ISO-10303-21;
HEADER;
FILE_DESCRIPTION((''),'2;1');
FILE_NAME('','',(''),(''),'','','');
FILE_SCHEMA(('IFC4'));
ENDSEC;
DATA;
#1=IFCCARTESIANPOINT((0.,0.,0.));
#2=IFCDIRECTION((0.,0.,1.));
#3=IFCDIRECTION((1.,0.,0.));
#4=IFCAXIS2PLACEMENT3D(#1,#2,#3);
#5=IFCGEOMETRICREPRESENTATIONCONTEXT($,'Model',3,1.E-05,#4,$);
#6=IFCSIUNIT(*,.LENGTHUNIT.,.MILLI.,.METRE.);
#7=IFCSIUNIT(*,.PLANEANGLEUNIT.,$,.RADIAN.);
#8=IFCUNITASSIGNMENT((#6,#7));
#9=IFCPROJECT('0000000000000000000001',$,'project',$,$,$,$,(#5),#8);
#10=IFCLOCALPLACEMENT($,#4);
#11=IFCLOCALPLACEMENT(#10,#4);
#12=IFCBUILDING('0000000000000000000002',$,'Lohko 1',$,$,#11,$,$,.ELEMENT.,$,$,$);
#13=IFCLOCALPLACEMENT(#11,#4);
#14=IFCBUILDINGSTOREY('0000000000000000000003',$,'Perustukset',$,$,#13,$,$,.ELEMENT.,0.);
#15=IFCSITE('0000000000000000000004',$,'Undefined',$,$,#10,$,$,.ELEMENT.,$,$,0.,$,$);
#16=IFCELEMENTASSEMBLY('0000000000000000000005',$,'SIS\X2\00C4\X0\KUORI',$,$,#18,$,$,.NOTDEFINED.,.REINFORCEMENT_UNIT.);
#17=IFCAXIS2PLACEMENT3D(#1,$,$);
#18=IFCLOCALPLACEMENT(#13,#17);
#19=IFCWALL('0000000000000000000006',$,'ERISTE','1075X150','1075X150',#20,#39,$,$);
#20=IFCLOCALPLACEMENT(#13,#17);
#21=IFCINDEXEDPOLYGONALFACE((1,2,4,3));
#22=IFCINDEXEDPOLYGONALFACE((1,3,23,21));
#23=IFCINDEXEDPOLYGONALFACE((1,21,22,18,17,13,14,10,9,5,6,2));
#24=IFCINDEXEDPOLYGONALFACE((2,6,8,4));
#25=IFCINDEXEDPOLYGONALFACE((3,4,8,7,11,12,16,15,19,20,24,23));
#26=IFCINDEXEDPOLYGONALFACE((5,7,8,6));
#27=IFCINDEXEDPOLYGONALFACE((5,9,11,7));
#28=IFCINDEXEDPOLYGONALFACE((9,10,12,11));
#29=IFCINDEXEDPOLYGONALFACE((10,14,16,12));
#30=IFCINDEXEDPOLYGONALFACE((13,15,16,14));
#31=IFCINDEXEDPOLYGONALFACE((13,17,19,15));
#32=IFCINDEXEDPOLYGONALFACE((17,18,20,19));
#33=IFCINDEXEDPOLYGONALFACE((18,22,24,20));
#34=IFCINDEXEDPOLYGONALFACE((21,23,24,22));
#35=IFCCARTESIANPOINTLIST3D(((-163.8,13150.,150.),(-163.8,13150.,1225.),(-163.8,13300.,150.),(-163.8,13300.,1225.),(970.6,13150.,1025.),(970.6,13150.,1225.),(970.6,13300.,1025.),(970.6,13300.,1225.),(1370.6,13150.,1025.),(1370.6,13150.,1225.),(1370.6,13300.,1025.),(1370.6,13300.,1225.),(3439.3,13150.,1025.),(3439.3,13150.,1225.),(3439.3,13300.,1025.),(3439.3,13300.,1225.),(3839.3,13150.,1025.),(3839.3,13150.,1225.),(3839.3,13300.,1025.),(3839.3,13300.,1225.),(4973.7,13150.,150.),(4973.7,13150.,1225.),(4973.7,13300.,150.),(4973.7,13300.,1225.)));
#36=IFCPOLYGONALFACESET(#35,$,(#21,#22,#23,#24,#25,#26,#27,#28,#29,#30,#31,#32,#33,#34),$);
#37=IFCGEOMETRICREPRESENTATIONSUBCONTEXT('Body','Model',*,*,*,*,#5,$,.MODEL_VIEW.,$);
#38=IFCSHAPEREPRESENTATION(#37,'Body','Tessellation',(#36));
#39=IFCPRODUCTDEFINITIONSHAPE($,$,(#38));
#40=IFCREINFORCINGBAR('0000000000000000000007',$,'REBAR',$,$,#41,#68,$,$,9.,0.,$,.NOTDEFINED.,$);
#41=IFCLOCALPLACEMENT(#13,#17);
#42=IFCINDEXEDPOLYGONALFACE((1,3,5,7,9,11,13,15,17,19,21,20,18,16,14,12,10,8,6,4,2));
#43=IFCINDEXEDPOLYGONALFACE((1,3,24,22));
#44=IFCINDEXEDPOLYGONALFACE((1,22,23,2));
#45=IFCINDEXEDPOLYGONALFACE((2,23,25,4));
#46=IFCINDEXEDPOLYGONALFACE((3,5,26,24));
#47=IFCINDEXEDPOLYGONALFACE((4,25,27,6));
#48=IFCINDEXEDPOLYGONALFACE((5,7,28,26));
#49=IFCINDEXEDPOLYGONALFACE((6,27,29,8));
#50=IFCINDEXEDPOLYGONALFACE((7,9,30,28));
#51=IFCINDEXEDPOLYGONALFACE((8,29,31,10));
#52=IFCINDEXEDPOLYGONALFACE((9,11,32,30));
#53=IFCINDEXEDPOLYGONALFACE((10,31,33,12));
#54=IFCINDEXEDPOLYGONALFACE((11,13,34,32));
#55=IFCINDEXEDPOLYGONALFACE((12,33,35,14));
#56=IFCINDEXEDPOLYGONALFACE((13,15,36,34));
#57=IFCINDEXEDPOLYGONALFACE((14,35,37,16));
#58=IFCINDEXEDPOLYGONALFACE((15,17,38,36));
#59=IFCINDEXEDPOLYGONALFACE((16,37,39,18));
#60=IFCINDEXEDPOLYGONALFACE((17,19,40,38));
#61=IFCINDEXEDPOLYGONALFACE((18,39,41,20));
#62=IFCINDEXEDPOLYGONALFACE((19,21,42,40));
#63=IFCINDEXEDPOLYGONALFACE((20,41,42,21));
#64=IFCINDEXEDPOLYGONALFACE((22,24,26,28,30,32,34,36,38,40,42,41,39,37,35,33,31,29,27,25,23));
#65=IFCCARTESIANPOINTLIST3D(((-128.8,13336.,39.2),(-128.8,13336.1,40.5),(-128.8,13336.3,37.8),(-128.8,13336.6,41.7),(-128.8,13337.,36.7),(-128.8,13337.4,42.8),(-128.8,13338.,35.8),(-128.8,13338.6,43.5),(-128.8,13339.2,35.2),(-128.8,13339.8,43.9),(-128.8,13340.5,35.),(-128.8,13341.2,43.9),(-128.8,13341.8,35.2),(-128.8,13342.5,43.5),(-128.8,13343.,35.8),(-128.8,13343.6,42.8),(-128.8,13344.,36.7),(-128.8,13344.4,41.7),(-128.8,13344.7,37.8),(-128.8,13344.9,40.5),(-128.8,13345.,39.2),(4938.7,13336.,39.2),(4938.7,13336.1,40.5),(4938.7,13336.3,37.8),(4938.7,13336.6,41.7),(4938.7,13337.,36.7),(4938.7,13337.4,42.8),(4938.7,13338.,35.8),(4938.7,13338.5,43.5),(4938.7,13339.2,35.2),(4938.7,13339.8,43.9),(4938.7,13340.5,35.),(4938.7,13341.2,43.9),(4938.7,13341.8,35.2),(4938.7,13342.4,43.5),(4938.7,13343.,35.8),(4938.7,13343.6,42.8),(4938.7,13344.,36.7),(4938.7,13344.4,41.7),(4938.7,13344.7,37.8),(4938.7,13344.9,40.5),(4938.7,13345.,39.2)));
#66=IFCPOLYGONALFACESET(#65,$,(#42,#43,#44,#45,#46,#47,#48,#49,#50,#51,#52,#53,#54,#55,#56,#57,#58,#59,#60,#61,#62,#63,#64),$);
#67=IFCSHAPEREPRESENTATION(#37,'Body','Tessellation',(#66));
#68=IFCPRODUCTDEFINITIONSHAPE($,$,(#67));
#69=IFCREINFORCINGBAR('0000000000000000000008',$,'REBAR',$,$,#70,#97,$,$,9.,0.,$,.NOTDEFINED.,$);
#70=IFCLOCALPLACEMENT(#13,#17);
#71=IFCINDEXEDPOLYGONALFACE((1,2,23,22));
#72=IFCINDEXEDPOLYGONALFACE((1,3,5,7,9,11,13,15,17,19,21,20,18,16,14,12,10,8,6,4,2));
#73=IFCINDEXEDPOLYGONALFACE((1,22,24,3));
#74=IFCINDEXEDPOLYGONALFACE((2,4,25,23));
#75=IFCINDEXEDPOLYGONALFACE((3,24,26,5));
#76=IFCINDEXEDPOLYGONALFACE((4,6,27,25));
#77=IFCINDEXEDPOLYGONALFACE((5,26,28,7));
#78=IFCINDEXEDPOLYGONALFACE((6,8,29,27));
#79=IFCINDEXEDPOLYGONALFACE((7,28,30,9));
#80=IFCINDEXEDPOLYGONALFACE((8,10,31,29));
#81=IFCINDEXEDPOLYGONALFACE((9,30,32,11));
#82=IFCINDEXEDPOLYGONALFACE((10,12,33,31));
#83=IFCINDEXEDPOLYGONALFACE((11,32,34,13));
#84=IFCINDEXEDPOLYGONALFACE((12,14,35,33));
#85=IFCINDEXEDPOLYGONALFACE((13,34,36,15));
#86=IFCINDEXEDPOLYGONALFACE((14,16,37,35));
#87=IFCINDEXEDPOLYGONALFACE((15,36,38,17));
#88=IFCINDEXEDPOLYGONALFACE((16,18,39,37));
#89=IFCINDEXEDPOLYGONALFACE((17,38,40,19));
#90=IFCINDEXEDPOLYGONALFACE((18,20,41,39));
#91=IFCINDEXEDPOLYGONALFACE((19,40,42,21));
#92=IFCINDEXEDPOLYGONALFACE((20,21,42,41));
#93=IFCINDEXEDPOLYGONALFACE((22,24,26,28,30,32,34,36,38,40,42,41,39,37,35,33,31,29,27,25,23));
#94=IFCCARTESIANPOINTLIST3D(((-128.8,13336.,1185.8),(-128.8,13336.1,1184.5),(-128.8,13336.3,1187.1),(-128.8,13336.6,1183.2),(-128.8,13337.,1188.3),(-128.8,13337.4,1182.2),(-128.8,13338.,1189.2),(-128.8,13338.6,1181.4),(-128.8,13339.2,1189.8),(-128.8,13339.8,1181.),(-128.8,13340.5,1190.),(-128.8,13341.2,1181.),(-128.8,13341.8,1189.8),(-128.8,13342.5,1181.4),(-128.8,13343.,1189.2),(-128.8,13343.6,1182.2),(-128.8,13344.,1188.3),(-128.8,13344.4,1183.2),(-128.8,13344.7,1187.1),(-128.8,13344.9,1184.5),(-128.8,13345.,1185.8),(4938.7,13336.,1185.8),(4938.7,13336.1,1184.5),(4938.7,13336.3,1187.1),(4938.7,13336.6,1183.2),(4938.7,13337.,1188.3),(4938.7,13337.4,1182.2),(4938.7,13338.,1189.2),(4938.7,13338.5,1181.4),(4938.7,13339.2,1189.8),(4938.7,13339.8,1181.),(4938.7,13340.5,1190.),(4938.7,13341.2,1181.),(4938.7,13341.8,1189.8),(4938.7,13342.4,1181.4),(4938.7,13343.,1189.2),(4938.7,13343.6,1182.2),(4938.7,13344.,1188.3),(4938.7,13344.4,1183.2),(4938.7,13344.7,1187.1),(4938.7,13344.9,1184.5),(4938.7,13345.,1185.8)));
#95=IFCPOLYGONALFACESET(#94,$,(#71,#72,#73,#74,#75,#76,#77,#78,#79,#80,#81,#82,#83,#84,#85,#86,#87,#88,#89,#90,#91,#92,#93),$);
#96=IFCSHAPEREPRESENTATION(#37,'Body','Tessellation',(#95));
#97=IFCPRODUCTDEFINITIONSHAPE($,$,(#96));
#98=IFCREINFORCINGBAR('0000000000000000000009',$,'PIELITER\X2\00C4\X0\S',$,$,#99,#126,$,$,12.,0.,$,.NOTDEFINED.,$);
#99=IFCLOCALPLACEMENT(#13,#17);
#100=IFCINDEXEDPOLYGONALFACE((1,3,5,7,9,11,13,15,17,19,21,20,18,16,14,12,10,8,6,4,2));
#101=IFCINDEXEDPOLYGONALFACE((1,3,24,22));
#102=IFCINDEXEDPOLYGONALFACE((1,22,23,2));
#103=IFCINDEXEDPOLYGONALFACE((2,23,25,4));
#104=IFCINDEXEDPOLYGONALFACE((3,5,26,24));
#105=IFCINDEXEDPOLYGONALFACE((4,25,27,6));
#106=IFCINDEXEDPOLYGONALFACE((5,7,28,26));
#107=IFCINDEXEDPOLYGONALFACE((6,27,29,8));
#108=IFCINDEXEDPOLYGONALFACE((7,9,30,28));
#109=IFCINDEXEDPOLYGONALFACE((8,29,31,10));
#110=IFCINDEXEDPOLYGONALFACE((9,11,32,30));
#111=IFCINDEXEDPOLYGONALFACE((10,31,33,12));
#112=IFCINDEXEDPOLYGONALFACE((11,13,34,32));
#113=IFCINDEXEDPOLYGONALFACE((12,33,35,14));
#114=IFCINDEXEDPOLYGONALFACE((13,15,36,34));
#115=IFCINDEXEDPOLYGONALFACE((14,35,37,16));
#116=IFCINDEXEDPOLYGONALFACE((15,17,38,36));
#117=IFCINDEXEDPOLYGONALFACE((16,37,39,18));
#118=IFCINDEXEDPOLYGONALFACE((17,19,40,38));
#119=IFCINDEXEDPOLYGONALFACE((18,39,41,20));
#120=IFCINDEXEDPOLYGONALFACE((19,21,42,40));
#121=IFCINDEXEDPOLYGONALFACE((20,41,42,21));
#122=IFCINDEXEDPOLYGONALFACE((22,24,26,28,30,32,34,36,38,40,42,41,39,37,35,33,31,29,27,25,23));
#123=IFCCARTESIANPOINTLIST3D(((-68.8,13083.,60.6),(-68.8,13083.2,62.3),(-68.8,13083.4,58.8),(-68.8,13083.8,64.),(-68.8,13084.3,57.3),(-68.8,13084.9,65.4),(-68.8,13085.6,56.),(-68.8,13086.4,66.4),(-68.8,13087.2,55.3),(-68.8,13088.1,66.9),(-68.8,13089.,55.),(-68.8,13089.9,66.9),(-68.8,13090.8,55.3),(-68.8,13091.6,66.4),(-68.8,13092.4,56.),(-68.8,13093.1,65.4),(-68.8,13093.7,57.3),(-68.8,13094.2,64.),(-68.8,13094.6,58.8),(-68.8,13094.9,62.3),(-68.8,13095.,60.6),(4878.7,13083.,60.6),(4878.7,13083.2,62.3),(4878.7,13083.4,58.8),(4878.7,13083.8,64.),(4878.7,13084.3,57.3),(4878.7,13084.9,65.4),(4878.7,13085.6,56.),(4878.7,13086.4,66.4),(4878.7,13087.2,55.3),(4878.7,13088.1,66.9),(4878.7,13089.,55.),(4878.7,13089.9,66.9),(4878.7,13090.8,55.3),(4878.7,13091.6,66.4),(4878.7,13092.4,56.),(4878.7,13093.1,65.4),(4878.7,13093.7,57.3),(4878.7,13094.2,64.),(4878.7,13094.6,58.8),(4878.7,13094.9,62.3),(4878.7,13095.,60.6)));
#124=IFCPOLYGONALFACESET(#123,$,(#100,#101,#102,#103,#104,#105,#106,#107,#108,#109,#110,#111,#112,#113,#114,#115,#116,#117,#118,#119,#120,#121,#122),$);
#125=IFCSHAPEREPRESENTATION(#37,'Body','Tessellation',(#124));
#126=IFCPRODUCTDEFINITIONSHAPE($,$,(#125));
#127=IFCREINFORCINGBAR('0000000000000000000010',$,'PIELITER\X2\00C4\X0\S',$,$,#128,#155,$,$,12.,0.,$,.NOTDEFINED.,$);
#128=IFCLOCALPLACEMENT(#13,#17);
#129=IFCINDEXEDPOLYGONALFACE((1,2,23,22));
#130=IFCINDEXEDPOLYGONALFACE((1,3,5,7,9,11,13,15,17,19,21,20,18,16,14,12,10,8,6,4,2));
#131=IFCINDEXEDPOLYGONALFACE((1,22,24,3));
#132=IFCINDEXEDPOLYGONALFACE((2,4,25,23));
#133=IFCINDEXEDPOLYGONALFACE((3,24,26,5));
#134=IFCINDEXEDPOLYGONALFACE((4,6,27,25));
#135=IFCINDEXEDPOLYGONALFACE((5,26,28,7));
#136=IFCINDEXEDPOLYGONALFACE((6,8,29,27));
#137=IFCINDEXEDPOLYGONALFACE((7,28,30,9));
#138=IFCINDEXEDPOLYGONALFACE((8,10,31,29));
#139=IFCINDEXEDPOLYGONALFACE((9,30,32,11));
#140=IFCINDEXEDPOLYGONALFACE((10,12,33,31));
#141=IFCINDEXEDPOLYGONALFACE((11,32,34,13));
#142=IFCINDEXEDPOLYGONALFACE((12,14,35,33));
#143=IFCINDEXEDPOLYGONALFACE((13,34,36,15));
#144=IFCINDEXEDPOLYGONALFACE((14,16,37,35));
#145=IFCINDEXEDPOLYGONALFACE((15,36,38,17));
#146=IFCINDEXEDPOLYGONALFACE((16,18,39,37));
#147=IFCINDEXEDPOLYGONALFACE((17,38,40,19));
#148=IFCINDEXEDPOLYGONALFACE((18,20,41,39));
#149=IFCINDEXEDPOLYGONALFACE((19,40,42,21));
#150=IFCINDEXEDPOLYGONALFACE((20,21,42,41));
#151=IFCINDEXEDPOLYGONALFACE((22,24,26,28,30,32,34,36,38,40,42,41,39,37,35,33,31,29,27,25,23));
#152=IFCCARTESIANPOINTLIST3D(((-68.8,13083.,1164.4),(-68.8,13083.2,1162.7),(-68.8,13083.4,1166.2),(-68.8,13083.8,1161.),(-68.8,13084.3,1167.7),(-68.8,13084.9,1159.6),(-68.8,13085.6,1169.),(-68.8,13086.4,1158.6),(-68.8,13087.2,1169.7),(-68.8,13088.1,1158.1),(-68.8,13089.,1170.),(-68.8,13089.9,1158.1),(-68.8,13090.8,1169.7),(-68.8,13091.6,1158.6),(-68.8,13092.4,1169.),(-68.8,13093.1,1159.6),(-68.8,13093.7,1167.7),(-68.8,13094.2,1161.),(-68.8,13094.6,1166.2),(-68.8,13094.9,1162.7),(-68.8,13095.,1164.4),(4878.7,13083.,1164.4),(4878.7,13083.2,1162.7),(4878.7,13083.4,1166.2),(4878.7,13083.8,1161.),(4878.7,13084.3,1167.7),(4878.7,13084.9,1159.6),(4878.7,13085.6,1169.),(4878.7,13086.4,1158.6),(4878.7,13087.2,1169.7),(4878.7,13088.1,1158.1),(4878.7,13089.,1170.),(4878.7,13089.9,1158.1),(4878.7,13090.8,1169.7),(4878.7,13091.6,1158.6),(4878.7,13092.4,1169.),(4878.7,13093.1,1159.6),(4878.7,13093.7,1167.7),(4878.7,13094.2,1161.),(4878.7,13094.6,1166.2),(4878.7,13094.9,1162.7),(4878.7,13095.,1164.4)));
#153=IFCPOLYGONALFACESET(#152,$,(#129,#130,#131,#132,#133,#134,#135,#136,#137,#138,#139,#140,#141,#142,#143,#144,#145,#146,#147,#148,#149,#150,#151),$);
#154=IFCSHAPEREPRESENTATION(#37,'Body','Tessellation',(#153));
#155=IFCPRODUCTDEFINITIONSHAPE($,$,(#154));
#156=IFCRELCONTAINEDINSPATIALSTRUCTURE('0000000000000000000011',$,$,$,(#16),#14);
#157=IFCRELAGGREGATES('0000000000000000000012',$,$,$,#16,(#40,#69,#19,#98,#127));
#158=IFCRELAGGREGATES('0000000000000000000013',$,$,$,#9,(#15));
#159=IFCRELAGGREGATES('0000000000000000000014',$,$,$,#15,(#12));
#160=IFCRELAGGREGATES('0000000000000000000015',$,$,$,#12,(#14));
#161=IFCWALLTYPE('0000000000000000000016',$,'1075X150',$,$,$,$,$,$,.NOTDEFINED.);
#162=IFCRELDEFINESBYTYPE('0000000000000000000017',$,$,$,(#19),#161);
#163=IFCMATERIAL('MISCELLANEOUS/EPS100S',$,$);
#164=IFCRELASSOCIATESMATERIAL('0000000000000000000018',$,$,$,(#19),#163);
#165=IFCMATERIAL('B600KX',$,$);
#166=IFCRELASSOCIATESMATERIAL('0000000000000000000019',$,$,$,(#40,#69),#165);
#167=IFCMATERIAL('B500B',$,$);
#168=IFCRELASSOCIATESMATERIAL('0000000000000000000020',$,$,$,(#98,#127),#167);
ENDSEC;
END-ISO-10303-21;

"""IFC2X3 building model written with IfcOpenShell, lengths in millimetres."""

from ifc_helpers import new_model, entity, si_unit, frame, frame_2d, origin_with_axes, place, context, subcontext, project, spatial, polyline, rectangle, outline, extrude, boolean, source, transform, mapped, material, type_object, element, aggregate, save


model = new_model("IFC2X3")

# Units and contexts
model_context = context("Model", 3, precision=1e-05, world=origin_with_axes())
body_context = subcontext(model_context, "Body", "Model", "MODEL_VIEW")
ifc_project = project(units=[si_unit("LENGTHUNIT", "METRE", prefix="MILLI"), si_unit("PLANEANGLEUNIT", "RADIAN")], contexts=[model_context])

# Site, building, storey
site_placement = place(None, origin_with_axes())
site = spatial("IfcSite", under=ifc_project, at=site_placement, Name="Undefined", CompositionType="ELEMENT", RefElevation=0.0)
building_placement = place(site_placement, origin_with_axes())
building = spatial("IfcBuilding", under=site, at=building_placement, Name="Lohko 1", CompositionType="ELEMENT")
storey_placement = place(building_placement, origin_with_axes())
storey = spatial("IfcBuildingStorey", under=building, at=storey_placement, Name="Perustukset", CompositionType="ELEMENT", Elevation=0.0)

# Element assembly, wall, reinforcing bars
assembly_placement = place(storey_placement, origin_with_axes())
assembly = element("IfcElementAssembly", 1, at=assembly_placement, inside=storey, Name="SISÄKUORI", AssemblyPlace="NOTDEFINED", PredefinedType="REINFORCEMENT_UNIT")
ifc_material_1 = material(Name="MISCELLANEOUS/EPS100S")
wall_type_1 = type_object("IfcWallType", Name="1075X150", PredefinedType="NOTDEFINED")
wall_1_placement = place(assembly_placement, frame((-163.8, 13225.0, 150.0), z_axis=(0.0, 0.0, 1.0), x_axis=(1.0, 0.0, 0.0)))
wall_1 = element("IfcWall", 2, at=wall_1_placement, type_object=wall_type_1, material=ifc_material_1, Name="ERISTE", Description="1075X150", ObjectType="1075X150", context=body_context, shape_type="CSG", body=[
    boolean("DIFFERENCE", boolean("DIFFERENCE", extrude(rectangle(XDim=5137.5, YDim=150.0, at=frame_2d((0.0, 2568.7), x_axis=(0.0, -1.0))), frame((0.0, 0.0, 0.0), z_axis=(0.0, 0.0, 1.0), x_axis=(0.0, -1.0, 0.0)), (0.0, 0.0, 1.0), 1075.0), extrude(outline(polyline([(0.0, 0.0), (200.0, 0.0), (200.0, 400.0), (0.0, 400.0), (0.0, 0.0)])), frame((3603.1, 78.0, 1075.0), z_axis=(0.0, -1.0, 0.0), x_axis=(0.0, 0.0, -1.0)), (0.0, 0.0, 1.0), 156.0)), extrude(outline(polyline([(0.0, 0.0), (200.0, 0.0), (200.0, 400.0), (0.0, 400.0), (0.0, 0.0)])), frame((1134.4, 78.0, 1075.0), z_axis=(0.0, -1.0, 0.0), x_axis=(0.0, 0.0, -1.0)), (0.0, 0.0, 1.0), 156.0)),
])
ifc_material_2 = material(Name="B600KX")
shared_shape_1 = source(origin_with_axes(), body_context, "Body", "AdvancedSweptSolid", [
    entity("IfcSweptDiskSolid", entity("IfcTrimmedCurve", entity("IfcLine", entity("IfcCartesianPoint", [0.0, 0.0, 0.0]), entity("IfcVector", entity("IfcDirection", [1.0, 0.0, 0.0]), 1.0)), [entity("IfcParameterValue", 0.0)], [entity("IfcParameterValue", 5067.479996)], True, "PARAMETER"), 4.5, None, 0.0, 5067.5),
])
reinforcing_bar_1_placement = place(assembly_placement, frame((-128.8, 13340.5, 39.5), z_axis=(0.0, 0.0, -1.0), x_axis=(1.0, -0.000003, 0.0)))
reinforcing_bar_1 = element("IfcReinforcingBar", 3, at=reinforcing_bar_1_placement, material=ifc_material_2, Name="REBAR", BarRole="NOTDEFINED", CrossSectionArea=0.0, NominalDiameter=9.0, context=body_context, shape_type="MappedRepresentation", body=[
    mapped(shared_shape_1, transform((0.0, 0.0, 0.0))),
])
shared_shape_2 = source(origin_with_axes(), body_context, "Body", "AdvancedSweptSolid", [
    entity("IfcSweptDiskSolid", entity("IfcTrimmedCurve", entity("IfcLine", entity("IfcCartesianPoint", [0.0, 0.0, 0.0]), entity("IfcVector", entity("IfcDirection", [1.0, 0.0, 0.0]), 1.0)), [entity("IfcParameterValue", 0.0)], [entity("IfcParameterValue", 5067.479996)], True, "PARAMETER"), 4.5, None, 0.0, 5067.5),
])
reinforcing_bar_2_placement = place(assembly_placement, frame((4938.7, 13340.5, 1185.5), z_axis=(0.0, 0.0, 1.0), x_axis=(-1.0, 0.000003, 0.0)))
reinforcing_bar_2 = element("IfcReinforcingBar", 4, at=reinforcing_bar_2_placement, material=ifc_material_2, Name="REBAR", BarRole="NOTDEFINED", CrossSectionArea=0.0, NominalDiameter=9.0, context=body_context, shape_type="MappedRepresentation", body=[
    mapped(shared_shape_2, transform((0.0, 0.0, 0.0))),
])
ifc_material_3 = material(Name="B500B")
shared_shape_3 = source(origin_with_axes(), body_context, "Body", "AdvancedSweptSolid", [
    entity("IfcSweptDiskSolid", entity("IfcTrimmedCurve", entity("IfcLine", entity("IfcCartesianPoint", [0.0, 0.0, 0.0]), entity("IfcVector", entity("IfcDirection", [1.0, 0.0, 0.0]), 1.0)), [entity("IfcParameterValue", 0.0)], [entity("IfcParameterValue", 4947.47882)], True, "PARAMETER"), 6.0, None, 0.0, 4947.5),
])
reinforcing_bar_3_placement = place(assembly_placement, frame((-68.8, 13089.0, 61.0), z_axis=(0.0, 0.0, -1.0), x_axis=(1.0, 0.0, 0.0)))
reinforcing_bar_3 = element("IfcReinforcingBar", 5, at=reinforcing_bar_3_placement, material=ifc_material_3, Name="PIELITERÄS", BarRole="NOTDEFINED", CrossSectionArea=0.0, NominalDiameter=12.0, context=body_context, shape_type="MappedRepresentation", body=[
    mapped(shared_shape_3, transform((0.0, 0.0, 0.0))),
])
shared_shape_4 = source(origin_with_axes(), body_context, "Body", "AdvancedSweptSolid", [
    entity("IfcSweptDiskSolid", entity("IfcTrimmedCurve", entity("IfcLine", entity("IfcCartesianPoint", [0.0, 0.0, 0.0]), entity("IfcVector", entity("IfcDirection", [1.0, 0.0, 0.0]), 1.0)), [entity("IfcParameterValue", 0.0)], [entity("IfcParameterValue", 4947.47882)], True, "PARAMETER"), 6.0, None, 0.0, 4947.5),
])
reinforcing_bar_4_placement = place(assembly_placement, frame((4878.7, 13089.0, 1164.0), z_axis=(0.0, 0.0, 1.0), x_axis=(-1.0, 0.0, 0.0)))
reinforcing_bar_4 = element("IfcReinforcingBar", 6, at=reinforcing_bar_4_placement, material=ifc_material_3, Name="PIELITERÄS", BarRole="NOTDEFINED", CrossSectionArea=0.0, NominalDiameter=12.0, context=body_context, shape_type="MappedRepresentation", body=[
    mapped(shared_shape_4, transform((0.0, 0.0, 0.0))),
])
aggregate(assembly, [reinforcing_bar_1, reinforcing_bar_2, wall_1, reinforcing_bar_3, reinforcing_bar_4])

save(model, "model.ifc")
